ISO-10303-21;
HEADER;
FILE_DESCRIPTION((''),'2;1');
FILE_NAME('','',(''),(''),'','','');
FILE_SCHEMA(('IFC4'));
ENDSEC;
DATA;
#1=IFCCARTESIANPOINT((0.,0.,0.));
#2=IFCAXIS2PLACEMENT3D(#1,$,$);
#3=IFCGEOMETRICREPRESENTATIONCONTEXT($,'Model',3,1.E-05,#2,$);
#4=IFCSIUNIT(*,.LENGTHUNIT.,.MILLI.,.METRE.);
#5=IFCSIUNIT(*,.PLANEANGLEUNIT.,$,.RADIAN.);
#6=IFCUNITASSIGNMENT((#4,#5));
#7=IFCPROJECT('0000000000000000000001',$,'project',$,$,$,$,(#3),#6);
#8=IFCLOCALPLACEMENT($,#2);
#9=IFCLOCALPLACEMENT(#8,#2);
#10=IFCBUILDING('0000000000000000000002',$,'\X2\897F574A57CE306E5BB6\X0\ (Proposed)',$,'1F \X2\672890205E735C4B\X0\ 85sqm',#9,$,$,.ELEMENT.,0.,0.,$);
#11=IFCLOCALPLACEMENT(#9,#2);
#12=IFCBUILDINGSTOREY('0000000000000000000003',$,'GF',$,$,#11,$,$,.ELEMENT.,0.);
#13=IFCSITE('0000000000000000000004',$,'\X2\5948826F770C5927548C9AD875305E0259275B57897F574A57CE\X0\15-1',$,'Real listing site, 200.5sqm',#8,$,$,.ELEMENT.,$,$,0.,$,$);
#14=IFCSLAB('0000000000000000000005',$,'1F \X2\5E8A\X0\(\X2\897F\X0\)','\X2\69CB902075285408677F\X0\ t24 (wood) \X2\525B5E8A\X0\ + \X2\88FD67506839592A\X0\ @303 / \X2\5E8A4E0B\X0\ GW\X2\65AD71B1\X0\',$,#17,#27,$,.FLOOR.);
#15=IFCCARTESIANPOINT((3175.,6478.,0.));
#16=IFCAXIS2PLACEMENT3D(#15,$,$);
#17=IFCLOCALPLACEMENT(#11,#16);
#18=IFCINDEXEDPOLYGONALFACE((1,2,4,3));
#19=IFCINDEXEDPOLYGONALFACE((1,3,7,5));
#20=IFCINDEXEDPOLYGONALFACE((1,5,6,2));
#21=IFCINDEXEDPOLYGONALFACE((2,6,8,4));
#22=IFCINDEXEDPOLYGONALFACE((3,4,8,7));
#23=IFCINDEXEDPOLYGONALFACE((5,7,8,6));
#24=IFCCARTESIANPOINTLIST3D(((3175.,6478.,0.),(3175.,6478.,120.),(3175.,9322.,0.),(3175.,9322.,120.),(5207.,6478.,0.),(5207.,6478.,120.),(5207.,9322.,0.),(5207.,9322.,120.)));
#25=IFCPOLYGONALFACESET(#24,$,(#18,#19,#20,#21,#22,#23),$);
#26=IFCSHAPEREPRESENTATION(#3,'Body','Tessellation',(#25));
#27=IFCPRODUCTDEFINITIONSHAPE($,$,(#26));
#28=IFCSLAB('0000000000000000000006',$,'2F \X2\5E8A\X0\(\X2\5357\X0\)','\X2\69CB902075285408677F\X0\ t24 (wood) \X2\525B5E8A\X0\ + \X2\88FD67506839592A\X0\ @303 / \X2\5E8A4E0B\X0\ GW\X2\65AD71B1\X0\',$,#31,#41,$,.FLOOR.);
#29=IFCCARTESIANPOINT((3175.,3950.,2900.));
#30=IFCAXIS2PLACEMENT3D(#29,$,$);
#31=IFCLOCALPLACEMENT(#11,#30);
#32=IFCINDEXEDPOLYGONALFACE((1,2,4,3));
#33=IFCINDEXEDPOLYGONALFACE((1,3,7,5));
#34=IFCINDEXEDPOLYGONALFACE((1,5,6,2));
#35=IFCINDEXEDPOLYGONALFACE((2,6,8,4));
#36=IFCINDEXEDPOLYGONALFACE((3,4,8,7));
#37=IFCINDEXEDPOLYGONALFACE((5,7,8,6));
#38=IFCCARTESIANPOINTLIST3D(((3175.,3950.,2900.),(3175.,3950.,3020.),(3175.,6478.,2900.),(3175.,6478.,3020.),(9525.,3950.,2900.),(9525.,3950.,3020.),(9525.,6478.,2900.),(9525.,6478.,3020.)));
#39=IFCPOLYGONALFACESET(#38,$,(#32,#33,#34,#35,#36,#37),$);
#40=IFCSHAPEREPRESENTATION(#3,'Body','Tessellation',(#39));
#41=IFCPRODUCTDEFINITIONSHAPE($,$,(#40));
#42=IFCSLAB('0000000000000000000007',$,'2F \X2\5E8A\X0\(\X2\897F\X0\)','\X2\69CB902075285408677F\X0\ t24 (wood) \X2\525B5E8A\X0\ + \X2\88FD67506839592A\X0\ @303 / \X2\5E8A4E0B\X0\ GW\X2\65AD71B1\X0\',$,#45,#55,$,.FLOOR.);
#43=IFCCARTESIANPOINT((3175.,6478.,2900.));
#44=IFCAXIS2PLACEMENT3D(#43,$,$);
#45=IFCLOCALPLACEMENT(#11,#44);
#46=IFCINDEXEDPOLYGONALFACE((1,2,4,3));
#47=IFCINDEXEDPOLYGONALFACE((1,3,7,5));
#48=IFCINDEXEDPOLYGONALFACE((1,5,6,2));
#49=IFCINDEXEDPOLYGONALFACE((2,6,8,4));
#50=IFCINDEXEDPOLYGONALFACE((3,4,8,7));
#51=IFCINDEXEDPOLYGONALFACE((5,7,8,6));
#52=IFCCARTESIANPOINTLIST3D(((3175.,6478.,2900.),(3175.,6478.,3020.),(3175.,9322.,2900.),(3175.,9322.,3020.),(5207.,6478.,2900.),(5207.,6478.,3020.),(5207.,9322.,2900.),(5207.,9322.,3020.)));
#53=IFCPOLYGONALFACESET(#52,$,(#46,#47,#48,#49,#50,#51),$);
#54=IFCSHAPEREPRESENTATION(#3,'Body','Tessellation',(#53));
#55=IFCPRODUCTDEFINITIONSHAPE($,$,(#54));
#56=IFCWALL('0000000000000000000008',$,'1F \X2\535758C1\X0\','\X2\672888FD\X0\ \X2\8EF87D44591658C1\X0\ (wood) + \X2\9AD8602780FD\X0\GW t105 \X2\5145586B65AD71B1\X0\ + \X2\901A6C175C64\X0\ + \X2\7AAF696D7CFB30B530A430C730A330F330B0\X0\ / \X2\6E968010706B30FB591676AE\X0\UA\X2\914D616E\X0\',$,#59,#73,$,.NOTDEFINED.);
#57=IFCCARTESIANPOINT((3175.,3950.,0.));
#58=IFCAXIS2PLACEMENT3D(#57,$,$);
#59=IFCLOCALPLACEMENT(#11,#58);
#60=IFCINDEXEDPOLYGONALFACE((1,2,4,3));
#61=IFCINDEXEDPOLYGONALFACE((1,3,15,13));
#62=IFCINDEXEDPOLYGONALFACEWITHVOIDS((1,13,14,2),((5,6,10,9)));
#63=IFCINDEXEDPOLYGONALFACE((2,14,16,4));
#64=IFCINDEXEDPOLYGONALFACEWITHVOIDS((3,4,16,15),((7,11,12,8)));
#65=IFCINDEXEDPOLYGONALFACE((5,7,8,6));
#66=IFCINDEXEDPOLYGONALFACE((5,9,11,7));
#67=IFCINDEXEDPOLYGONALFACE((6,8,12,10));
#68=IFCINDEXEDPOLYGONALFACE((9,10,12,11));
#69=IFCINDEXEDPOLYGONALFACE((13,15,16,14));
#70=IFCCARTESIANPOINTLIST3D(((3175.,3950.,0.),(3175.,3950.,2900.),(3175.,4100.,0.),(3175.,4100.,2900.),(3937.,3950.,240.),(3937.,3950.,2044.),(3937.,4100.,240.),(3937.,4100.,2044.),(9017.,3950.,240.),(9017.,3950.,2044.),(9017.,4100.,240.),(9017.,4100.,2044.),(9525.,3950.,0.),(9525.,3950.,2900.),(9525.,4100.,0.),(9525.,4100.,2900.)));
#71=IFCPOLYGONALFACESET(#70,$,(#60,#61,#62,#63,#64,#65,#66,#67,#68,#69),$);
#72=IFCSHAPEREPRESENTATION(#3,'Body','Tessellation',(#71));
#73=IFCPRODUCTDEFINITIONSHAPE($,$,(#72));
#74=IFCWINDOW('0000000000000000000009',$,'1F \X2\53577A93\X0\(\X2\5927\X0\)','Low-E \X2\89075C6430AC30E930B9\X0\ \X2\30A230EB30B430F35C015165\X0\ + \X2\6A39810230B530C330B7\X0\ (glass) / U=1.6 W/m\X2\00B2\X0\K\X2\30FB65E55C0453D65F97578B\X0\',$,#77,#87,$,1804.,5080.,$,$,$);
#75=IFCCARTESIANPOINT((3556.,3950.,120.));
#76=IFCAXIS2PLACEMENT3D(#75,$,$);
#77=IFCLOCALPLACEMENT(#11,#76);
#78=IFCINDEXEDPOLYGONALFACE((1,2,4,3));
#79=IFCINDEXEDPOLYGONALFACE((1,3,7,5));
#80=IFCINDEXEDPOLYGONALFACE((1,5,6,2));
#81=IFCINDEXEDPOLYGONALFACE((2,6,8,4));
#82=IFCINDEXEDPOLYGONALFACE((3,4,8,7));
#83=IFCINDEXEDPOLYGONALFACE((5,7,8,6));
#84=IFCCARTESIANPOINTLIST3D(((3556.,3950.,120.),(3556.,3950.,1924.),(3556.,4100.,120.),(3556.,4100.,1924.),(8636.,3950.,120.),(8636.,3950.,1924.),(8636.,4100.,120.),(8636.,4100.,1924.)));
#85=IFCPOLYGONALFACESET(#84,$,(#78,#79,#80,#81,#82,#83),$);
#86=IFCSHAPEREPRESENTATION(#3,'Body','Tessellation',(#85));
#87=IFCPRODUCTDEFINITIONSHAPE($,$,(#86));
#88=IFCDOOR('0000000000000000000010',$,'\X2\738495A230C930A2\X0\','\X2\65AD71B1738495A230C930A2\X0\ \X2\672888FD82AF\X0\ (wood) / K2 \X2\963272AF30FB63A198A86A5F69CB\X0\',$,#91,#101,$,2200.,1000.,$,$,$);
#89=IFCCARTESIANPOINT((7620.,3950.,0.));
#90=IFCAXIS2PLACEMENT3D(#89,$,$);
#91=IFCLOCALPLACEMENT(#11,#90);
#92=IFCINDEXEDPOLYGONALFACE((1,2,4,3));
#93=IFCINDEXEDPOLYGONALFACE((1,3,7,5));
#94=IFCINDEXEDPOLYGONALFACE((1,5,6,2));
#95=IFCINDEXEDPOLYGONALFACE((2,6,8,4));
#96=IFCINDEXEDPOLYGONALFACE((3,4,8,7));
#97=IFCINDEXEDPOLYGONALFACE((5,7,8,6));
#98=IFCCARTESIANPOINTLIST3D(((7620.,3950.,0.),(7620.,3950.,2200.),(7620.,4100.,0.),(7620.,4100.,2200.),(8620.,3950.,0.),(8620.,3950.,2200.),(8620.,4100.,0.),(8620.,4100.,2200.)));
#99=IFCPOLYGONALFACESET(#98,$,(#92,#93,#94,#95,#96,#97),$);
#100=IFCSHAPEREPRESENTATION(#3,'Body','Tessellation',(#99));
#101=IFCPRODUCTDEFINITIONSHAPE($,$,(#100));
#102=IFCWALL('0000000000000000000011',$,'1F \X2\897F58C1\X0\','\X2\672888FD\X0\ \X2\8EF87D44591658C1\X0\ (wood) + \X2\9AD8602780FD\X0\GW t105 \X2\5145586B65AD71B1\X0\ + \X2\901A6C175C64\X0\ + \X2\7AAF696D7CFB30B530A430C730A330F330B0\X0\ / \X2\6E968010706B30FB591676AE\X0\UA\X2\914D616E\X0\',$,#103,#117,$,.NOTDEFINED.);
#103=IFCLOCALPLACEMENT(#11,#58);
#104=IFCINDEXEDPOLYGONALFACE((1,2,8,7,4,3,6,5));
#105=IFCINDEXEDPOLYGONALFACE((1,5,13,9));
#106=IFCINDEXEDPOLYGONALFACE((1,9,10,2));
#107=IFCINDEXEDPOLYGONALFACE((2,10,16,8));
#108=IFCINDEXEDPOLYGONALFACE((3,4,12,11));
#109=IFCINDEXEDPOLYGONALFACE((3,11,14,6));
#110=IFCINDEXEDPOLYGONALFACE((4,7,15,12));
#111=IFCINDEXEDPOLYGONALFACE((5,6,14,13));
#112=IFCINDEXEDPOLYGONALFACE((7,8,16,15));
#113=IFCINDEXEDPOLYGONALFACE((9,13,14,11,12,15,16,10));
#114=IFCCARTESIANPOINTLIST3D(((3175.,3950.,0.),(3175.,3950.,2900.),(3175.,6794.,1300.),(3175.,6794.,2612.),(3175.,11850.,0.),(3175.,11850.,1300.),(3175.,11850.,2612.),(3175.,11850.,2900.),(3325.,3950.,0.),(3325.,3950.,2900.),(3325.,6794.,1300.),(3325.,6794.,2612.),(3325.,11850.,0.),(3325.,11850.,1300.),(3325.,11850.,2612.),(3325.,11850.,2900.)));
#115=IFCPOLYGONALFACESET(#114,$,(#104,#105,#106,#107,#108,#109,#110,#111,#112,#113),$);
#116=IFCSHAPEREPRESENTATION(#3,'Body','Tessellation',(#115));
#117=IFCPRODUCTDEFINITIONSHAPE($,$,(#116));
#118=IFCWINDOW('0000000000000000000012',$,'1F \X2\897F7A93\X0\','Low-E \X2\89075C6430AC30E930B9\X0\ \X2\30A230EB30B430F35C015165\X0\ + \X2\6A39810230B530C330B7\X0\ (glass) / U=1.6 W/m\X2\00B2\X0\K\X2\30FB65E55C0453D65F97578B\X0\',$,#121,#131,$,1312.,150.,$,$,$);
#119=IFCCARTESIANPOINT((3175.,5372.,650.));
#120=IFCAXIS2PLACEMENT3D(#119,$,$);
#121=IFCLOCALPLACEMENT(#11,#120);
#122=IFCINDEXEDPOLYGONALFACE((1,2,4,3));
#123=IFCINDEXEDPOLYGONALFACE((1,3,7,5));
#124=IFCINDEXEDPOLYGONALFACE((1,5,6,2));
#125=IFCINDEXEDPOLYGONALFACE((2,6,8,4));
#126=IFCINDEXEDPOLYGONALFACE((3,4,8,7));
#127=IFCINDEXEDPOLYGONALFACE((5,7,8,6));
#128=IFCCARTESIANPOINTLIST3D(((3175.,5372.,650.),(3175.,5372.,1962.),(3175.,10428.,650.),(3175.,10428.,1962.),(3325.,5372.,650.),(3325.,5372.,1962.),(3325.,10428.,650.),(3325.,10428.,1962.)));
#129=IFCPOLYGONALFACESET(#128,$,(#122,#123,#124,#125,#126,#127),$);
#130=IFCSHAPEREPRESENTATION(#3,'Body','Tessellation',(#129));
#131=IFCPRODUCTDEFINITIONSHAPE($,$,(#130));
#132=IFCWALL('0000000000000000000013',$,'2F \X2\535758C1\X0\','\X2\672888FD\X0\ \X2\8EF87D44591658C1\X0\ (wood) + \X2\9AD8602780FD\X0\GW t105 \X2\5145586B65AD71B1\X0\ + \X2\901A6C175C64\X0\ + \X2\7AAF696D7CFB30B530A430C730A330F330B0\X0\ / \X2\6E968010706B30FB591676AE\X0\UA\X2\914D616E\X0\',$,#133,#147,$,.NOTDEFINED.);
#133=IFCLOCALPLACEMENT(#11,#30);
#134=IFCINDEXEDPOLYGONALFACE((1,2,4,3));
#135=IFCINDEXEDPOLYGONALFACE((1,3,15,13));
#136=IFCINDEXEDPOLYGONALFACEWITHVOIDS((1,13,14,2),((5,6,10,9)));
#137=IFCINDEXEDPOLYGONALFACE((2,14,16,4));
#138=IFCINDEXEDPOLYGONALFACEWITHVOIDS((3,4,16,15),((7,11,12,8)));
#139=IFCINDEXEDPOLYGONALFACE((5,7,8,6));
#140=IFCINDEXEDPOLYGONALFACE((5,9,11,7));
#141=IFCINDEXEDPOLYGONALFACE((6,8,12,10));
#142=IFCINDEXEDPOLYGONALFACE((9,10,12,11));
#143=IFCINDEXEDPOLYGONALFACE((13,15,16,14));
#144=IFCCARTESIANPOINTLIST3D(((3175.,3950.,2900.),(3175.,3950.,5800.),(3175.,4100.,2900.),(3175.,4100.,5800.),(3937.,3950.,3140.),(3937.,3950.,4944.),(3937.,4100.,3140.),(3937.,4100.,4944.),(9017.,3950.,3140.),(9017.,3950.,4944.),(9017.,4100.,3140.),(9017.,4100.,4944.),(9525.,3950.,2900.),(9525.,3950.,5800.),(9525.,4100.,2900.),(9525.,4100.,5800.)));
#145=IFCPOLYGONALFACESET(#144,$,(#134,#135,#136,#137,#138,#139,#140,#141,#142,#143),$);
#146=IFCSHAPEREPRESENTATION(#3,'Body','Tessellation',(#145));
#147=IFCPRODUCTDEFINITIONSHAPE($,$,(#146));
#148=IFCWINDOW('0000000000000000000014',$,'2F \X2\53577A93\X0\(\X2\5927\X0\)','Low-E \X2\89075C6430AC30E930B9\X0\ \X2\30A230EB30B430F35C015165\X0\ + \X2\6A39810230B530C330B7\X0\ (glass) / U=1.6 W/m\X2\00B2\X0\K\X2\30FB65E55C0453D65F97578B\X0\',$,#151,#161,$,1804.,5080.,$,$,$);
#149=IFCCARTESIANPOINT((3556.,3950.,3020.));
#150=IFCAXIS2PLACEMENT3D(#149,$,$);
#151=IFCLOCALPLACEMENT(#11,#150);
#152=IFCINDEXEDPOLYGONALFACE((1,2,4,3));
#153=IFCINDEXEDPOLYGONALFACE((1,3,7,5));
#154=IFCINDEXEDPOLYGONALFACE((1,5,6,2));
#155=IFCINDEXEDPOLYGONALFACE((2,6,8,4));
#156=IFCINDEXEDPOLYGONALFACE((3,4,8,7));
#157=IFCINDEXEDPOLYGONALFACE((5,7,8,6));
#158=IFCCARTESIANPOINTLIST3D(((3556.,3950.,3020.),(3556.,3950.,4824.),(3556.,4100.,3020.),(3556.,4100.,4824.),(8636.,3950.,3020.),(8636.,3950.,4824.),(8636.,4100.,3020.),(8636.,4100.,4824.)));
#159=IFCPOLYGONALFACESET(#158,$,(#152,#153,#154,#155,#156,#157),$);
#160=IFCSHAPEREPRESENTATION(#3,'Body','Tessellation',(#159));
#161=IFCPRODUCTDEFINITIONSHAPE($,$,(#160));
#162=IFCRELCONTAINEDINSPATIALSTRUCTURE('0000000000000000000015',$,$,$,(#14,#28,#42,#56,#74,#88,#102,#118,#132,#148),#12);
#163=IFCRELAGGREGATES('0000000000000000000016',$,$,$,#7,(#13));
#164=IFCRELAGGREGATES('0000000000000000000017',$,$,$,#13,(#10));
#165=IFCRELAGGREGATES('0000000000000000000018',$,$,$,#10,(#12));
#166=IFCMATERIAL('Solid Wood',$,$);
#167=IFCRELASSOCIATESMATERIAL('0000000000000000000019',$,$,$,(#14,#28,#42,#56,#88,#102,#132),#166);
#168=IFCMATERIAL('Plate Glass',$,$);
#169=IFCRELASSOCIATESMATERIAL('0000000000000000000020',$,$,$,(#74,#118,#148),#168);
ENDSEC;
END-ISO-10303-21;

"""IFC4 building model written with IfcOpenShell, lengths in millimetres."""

from ifc_helpers import new_model, si_unit, frame, frame_2d, origin, place, context, project, spatial, rectangle, extrude, material, element, fill, save


model = new_model("IFC4")

# Units and contexts
model_context = context("Model", 3, precision=1e-05, world=origin())
ifc_project = project(units=[si_unit("LENGTHUNIT", "METRE", prefix="MILLI"), si_unit("PLANEANGLEUNIT", "RADIAN")], contexts=[model_context])

# Site, building, storey
site_placement = place(None, origin())
site = spatial("IfcSite", under=ifc_project, at=site_placement, Name="奈良県大和高田市大字西坊城15-1", ObjectType="Real listing site, 200.5sqm", CompositionType="ELEMENT", RefElevation=0.0)
building_placement = place(site_placement, origin())
building = spatial("IfcBuilding", under=site, at=building_placement, Name="西坊城の家 (Proposed)", ObjectType="1F 木造平屋 85sqm", CompositionType="ELEMENT", ElevationOfRefHeight=0.0, ElevationOfTerrain=0.0)
storey_placement = place(building_placement, origin())
storey = spatial("IfcBuildingStorey", under=building, at=storey_placement, Name="GF", CompositionType="ELEMENT", Elevation=0.0)

# Slabs
ifc_material_1 = material(Name="Solid Wood")
slab_1_placement = place(storey_placement, frame((3175.0, 6478.0, 0.0)))
element("IfcSlab", 1, at=slab_1_placement, inside=storey, material=ifc_material_1, Name="1F 床(西)", Description="構造用合板 t24 (wood) 剛床 + 製材根太 @303 / 床下 GW断熱", PredefinedType="FLOOR", context=model_context, shape_type="SweptSolid", body=[
    extrude(rectangle(XDim=2032.0, YDim=2844.0, at=frame_2d((1016.0, 1422.0))), frame((3175.0, 6478.0, 0.0)), (0.0, 0.0, 1.0), 120.0),
])
slab_2_placement = place(storey_placement, frame((3175.0, 3950.0, 2900.0)))
element("IfcSlab", 2, at=slab_2_placement, inside=storey, material=ifc_material_1, Name="2F 床(南)", Description="構造用合板 t24 (wood) 剛床 + 製材根太 @303 / 床下 GW断熱", PredefinedType="FLOOR", context=model_context, shape_type="SweptSolid", body=[
    extrude(rectangle(XDim=6350.0, YDim=2528.0, at=frame_2d((3175.0, 1264.0))), frame((3175.0, 3950.0, 2900.0)), (0.0, 0.0, 1.0), 120.0),
])
slab_3_placement = place(storey_placement, frame((3175.0, 6478.0, 2900.0)))
element("IfcSlab", 3, at=slab_3_placement, inside=storey, material=ifc_material_1, Name="2F 床(西)", Description="構造用合板 t24 (wood) 剛床 + 製材根太 @303 / 床下 GW断熱", PredefinedType="FLOOR", context=model_context, shape_type="SweptSolid", body=[
    extrude(rectangle(XDim=2032.0, YDim=2844.0, at=frame_2d((1016.0, 1422.0))), frame((3175.0, 6478.0, 2900.0)), (0.0, 0.0, 1.0), 120.0),
])

# Wall, openings, window, door
wall_1_placement = place(storey_placement, frame((3175.0, 3950.0, 0.0)))
wall_1 = element("IfcWall", 4, at=wall_1_placement, inside=storey, material=ifc_material_1, Name="1F 南壁", Description="木製 軸組外壁 (wood) + 高性能GW t105 充填断熱 + 通気層 + 窯業系サイディング / 準耐火・外皮UA配慮", PredefinedType="NOTDEFINED", context=model_context, shape_type="SweptSolid", body=[
    extrude(rectangle(XDim=6350.0, YDim=150.0, at=frame_2d((3175.0, 75.0))), frame((3175.0, 3950.0, 0.0)), (0.0, 0.0, 1.0), 2900.0),
])
opening_1_placement = place(storey_placement, frame((3556.0, 3950.0, 120.0)))
opening_1 = element("IfcOpeningElement", 5, at=opening_1_placement, cuts=wall_1, PredefinedType="NOTDEFINED", context=model_context, shape_type="SweptSolid", body=[
    extrude(rectangle(XDim=5080.0, YDim=150.0, at=frame_2d((2540.0, 75.0))), frame((3556.0, 3950.0, 120.0)), (0.0, 0.0, 1.0), 1804.0),
])
opening_2_placement = place(storey_placement, frame((7620.0, 3950.0, 0.0)))
opening_2 = element("IfcOpeningElement", 6, at=opening_2_placement, cuts=wall_1, PredefinedType="NOTDEFINED", context=model_context, shape_type="SweptSolid", body=[
    extrude(rectangle(XDim=1000.0, YDim=150.0, at=frame_2d((500.0, 75.0))), frame((7620.0, 3950.0, 0.0)), (0.0, 0.0, 1.0), 2200.0),
])
ifc_material_2 = material(Name="Plate Glass")
window_1_placement = place(storey_placement, frame((3556.0, 3950.0, 120.0)))
window_1 = element("IfcWindow", 7, at=window_1_placement, inside=storey, material=ifc_material_2, Name="1F 南窓(大)", Description="Low-E 複層ガラス アルゴン封入 + 樹脂サッシ (glass) / U=1.6 W/m²K・日射取得型", OverallHeight=1804.0, OverallWidth=5080.0, context=model_context, shape_type="SweptSolid", body=[
    extrude(rectangle(XDim=5080.0, YDim=150.0, at=frame_2d((2540.0, 75.0))), frame((3556.0, 3950.0, 120.0)), (0.0, 0.0, 1.0), 1804.0),
])
fill(opening_1, window_1)
door_placement = place(storey_placement, frame((7620.0, 3950.0, 0.0)))
door = element("IfcDoor", 8, at=door_placement, inside=storey, material=ifc_material_1, Name="玄関ドア", Description="断熱玄関ドア 木製芯 (wood) / K2 防犯・採風機構", OverallHeight=2200.0, OverallWidth=1000.0, context=model_context, shape_type="SweptSolid", body=[
    extrude(rectangle(XDim=1000.0, YDim=150.0, at=frame_2d((500.0, 75.0))), frame((7620.0, 3950.0, 0.0)), (0.0, 0.0, 1.0), 2200.0),
])
fill(opening_2, door)

# Walls, openings, windows
wall_2_placement = place(storey_placement, frame((3175.0, 3950.0, 0.0)))
wall_2 = element("IfcWall", 9, at=wall_2_placement, inside=storey, material=ifc_material_1, Name="1F 西壁", Description="木製 軸組外壁 (wood) + 高性能GW t105 充填断熱 + 通気層 + 窯業系サイディング / 準耐火・外皮UA配慮", PredefinedType="NOTDEFINED", context=model_context, shape_type="SweptSolid", body=[
    extrude(rectangle(XDim=150.0, YDim=7900.0, at=frame_2d((75.0, 3950.0))), frame((3175.0, 3950.0, 0.0)), (0.0, 0.0, 1.0), 2900.0),
])
opening_3_placement = place(storey_placement, frame((3175.0, 5372.0, 650.0)))
opening_3 = element("IfcOpeningElement", 10, at=opening_3_placement, cuts=wall_2, PredefinedType="NOTDEFINED", context=model_context, shape_type="SweptSolid", body=[
    extrude(rectangle(XDim=150.0, YDim=5056.0, at=frame_2d((75.0, 2528.0))), frame((3175.0, 5372.0, 650.0)), (0.0, 0.0, 1.0), 1312.0),
])
window_2_placement = place(storey_placement, frame((3175.0, 5372.0, 650.0)))
window_2 = element("IfcWindow", 11, at=window_2_placement, inside=storey, material=ifc_material_2, Name="1F 西窓", Description="Low-E 複層ガラス アルゴン封入 + 樹脂サッシ (glass) / U=1.6 W/m²K・日射取得型", OverallHeight=1312.0, OverallWidth=150.0, context=model_context, shape_type="SweptSolid", body=[
    extrude(rectangle(XDim=150.0, YDim=5056.0, at=frame_2d((75.0, 2528.0))), frame((3175.0, 5372.0, 650.0)), (0.0, 0.0, 1.0), 1312.0),
])
fill(opening_3, window_2)
wall_3_placement = place(storey_placement, frame((3175.0, 3950.0, 2900.0)))
wall_3 = element("IfcWall", 12, at=wall_3_placement, inside=storey, material=ifc_material_1, Name="2F 南壁", Description="木製 軸組外壁 (wood) + 高性能GW t105 充填断熱 + 通気層 + 窯業系サイディング / 準耐火・外皮UA配慮", PredefinedType="NOTDEFINED", context=model_context, shape_type="SweptSolid", body=[
    extrude(rectangle(XDim=6350.0, YDim=150.0, at=frame_2d((3175.0, 75.0))), frame((3175.0, 3950.0, 2900.0)), (0.0, 0.0, 1.0), 2900.0),
])
opening_4_placement = place(storey_placement, frame((3556.0, 3950.0, 3020.0)))
opening_4 = element("IfcOpeningElement", 13, at=opening_4_placement, cuts=wall_3, PredefinedType="NOTDEFINED", context=model_context, shape_type="SweptSolid", body=[
    extrude(rectangle(XDim=5080.0, YDim=150.0, at=frame_2d((2540.0, 75.0))), frame((3556.0, 3950.0, 3020.0)), (0.0, 0.0, 1.0), 1804.0),
])
window_3_placement = place(storey_placement, frame((3556.0, 3950.0, 3020.0)))
window_3 = element("IfcWindow", 14, at=window_3_placement, inside=storey, material=ifc_material_2, Name="2F 南窓(大)", Description="Low-E 複層ガラス アルゴン封入 + 樹脂サッシ (glass) / U=1.6 W/m²K・日射取得型", OverallHeight=1804.0, OverallWidth=5080.0, context=model_context, shape_type="SweptSolid", body=[
    extrude(rectangle(XDim=5080.0, YDim=150.0, at=frame_2d((2540.0, 75.0))), frame((3556.0, 3950.0, 3020.0)), (0.0, 0.0, 1.0), 1804.0),
])
fill(opening_4, window_3)

save(model, "model.ifc")
